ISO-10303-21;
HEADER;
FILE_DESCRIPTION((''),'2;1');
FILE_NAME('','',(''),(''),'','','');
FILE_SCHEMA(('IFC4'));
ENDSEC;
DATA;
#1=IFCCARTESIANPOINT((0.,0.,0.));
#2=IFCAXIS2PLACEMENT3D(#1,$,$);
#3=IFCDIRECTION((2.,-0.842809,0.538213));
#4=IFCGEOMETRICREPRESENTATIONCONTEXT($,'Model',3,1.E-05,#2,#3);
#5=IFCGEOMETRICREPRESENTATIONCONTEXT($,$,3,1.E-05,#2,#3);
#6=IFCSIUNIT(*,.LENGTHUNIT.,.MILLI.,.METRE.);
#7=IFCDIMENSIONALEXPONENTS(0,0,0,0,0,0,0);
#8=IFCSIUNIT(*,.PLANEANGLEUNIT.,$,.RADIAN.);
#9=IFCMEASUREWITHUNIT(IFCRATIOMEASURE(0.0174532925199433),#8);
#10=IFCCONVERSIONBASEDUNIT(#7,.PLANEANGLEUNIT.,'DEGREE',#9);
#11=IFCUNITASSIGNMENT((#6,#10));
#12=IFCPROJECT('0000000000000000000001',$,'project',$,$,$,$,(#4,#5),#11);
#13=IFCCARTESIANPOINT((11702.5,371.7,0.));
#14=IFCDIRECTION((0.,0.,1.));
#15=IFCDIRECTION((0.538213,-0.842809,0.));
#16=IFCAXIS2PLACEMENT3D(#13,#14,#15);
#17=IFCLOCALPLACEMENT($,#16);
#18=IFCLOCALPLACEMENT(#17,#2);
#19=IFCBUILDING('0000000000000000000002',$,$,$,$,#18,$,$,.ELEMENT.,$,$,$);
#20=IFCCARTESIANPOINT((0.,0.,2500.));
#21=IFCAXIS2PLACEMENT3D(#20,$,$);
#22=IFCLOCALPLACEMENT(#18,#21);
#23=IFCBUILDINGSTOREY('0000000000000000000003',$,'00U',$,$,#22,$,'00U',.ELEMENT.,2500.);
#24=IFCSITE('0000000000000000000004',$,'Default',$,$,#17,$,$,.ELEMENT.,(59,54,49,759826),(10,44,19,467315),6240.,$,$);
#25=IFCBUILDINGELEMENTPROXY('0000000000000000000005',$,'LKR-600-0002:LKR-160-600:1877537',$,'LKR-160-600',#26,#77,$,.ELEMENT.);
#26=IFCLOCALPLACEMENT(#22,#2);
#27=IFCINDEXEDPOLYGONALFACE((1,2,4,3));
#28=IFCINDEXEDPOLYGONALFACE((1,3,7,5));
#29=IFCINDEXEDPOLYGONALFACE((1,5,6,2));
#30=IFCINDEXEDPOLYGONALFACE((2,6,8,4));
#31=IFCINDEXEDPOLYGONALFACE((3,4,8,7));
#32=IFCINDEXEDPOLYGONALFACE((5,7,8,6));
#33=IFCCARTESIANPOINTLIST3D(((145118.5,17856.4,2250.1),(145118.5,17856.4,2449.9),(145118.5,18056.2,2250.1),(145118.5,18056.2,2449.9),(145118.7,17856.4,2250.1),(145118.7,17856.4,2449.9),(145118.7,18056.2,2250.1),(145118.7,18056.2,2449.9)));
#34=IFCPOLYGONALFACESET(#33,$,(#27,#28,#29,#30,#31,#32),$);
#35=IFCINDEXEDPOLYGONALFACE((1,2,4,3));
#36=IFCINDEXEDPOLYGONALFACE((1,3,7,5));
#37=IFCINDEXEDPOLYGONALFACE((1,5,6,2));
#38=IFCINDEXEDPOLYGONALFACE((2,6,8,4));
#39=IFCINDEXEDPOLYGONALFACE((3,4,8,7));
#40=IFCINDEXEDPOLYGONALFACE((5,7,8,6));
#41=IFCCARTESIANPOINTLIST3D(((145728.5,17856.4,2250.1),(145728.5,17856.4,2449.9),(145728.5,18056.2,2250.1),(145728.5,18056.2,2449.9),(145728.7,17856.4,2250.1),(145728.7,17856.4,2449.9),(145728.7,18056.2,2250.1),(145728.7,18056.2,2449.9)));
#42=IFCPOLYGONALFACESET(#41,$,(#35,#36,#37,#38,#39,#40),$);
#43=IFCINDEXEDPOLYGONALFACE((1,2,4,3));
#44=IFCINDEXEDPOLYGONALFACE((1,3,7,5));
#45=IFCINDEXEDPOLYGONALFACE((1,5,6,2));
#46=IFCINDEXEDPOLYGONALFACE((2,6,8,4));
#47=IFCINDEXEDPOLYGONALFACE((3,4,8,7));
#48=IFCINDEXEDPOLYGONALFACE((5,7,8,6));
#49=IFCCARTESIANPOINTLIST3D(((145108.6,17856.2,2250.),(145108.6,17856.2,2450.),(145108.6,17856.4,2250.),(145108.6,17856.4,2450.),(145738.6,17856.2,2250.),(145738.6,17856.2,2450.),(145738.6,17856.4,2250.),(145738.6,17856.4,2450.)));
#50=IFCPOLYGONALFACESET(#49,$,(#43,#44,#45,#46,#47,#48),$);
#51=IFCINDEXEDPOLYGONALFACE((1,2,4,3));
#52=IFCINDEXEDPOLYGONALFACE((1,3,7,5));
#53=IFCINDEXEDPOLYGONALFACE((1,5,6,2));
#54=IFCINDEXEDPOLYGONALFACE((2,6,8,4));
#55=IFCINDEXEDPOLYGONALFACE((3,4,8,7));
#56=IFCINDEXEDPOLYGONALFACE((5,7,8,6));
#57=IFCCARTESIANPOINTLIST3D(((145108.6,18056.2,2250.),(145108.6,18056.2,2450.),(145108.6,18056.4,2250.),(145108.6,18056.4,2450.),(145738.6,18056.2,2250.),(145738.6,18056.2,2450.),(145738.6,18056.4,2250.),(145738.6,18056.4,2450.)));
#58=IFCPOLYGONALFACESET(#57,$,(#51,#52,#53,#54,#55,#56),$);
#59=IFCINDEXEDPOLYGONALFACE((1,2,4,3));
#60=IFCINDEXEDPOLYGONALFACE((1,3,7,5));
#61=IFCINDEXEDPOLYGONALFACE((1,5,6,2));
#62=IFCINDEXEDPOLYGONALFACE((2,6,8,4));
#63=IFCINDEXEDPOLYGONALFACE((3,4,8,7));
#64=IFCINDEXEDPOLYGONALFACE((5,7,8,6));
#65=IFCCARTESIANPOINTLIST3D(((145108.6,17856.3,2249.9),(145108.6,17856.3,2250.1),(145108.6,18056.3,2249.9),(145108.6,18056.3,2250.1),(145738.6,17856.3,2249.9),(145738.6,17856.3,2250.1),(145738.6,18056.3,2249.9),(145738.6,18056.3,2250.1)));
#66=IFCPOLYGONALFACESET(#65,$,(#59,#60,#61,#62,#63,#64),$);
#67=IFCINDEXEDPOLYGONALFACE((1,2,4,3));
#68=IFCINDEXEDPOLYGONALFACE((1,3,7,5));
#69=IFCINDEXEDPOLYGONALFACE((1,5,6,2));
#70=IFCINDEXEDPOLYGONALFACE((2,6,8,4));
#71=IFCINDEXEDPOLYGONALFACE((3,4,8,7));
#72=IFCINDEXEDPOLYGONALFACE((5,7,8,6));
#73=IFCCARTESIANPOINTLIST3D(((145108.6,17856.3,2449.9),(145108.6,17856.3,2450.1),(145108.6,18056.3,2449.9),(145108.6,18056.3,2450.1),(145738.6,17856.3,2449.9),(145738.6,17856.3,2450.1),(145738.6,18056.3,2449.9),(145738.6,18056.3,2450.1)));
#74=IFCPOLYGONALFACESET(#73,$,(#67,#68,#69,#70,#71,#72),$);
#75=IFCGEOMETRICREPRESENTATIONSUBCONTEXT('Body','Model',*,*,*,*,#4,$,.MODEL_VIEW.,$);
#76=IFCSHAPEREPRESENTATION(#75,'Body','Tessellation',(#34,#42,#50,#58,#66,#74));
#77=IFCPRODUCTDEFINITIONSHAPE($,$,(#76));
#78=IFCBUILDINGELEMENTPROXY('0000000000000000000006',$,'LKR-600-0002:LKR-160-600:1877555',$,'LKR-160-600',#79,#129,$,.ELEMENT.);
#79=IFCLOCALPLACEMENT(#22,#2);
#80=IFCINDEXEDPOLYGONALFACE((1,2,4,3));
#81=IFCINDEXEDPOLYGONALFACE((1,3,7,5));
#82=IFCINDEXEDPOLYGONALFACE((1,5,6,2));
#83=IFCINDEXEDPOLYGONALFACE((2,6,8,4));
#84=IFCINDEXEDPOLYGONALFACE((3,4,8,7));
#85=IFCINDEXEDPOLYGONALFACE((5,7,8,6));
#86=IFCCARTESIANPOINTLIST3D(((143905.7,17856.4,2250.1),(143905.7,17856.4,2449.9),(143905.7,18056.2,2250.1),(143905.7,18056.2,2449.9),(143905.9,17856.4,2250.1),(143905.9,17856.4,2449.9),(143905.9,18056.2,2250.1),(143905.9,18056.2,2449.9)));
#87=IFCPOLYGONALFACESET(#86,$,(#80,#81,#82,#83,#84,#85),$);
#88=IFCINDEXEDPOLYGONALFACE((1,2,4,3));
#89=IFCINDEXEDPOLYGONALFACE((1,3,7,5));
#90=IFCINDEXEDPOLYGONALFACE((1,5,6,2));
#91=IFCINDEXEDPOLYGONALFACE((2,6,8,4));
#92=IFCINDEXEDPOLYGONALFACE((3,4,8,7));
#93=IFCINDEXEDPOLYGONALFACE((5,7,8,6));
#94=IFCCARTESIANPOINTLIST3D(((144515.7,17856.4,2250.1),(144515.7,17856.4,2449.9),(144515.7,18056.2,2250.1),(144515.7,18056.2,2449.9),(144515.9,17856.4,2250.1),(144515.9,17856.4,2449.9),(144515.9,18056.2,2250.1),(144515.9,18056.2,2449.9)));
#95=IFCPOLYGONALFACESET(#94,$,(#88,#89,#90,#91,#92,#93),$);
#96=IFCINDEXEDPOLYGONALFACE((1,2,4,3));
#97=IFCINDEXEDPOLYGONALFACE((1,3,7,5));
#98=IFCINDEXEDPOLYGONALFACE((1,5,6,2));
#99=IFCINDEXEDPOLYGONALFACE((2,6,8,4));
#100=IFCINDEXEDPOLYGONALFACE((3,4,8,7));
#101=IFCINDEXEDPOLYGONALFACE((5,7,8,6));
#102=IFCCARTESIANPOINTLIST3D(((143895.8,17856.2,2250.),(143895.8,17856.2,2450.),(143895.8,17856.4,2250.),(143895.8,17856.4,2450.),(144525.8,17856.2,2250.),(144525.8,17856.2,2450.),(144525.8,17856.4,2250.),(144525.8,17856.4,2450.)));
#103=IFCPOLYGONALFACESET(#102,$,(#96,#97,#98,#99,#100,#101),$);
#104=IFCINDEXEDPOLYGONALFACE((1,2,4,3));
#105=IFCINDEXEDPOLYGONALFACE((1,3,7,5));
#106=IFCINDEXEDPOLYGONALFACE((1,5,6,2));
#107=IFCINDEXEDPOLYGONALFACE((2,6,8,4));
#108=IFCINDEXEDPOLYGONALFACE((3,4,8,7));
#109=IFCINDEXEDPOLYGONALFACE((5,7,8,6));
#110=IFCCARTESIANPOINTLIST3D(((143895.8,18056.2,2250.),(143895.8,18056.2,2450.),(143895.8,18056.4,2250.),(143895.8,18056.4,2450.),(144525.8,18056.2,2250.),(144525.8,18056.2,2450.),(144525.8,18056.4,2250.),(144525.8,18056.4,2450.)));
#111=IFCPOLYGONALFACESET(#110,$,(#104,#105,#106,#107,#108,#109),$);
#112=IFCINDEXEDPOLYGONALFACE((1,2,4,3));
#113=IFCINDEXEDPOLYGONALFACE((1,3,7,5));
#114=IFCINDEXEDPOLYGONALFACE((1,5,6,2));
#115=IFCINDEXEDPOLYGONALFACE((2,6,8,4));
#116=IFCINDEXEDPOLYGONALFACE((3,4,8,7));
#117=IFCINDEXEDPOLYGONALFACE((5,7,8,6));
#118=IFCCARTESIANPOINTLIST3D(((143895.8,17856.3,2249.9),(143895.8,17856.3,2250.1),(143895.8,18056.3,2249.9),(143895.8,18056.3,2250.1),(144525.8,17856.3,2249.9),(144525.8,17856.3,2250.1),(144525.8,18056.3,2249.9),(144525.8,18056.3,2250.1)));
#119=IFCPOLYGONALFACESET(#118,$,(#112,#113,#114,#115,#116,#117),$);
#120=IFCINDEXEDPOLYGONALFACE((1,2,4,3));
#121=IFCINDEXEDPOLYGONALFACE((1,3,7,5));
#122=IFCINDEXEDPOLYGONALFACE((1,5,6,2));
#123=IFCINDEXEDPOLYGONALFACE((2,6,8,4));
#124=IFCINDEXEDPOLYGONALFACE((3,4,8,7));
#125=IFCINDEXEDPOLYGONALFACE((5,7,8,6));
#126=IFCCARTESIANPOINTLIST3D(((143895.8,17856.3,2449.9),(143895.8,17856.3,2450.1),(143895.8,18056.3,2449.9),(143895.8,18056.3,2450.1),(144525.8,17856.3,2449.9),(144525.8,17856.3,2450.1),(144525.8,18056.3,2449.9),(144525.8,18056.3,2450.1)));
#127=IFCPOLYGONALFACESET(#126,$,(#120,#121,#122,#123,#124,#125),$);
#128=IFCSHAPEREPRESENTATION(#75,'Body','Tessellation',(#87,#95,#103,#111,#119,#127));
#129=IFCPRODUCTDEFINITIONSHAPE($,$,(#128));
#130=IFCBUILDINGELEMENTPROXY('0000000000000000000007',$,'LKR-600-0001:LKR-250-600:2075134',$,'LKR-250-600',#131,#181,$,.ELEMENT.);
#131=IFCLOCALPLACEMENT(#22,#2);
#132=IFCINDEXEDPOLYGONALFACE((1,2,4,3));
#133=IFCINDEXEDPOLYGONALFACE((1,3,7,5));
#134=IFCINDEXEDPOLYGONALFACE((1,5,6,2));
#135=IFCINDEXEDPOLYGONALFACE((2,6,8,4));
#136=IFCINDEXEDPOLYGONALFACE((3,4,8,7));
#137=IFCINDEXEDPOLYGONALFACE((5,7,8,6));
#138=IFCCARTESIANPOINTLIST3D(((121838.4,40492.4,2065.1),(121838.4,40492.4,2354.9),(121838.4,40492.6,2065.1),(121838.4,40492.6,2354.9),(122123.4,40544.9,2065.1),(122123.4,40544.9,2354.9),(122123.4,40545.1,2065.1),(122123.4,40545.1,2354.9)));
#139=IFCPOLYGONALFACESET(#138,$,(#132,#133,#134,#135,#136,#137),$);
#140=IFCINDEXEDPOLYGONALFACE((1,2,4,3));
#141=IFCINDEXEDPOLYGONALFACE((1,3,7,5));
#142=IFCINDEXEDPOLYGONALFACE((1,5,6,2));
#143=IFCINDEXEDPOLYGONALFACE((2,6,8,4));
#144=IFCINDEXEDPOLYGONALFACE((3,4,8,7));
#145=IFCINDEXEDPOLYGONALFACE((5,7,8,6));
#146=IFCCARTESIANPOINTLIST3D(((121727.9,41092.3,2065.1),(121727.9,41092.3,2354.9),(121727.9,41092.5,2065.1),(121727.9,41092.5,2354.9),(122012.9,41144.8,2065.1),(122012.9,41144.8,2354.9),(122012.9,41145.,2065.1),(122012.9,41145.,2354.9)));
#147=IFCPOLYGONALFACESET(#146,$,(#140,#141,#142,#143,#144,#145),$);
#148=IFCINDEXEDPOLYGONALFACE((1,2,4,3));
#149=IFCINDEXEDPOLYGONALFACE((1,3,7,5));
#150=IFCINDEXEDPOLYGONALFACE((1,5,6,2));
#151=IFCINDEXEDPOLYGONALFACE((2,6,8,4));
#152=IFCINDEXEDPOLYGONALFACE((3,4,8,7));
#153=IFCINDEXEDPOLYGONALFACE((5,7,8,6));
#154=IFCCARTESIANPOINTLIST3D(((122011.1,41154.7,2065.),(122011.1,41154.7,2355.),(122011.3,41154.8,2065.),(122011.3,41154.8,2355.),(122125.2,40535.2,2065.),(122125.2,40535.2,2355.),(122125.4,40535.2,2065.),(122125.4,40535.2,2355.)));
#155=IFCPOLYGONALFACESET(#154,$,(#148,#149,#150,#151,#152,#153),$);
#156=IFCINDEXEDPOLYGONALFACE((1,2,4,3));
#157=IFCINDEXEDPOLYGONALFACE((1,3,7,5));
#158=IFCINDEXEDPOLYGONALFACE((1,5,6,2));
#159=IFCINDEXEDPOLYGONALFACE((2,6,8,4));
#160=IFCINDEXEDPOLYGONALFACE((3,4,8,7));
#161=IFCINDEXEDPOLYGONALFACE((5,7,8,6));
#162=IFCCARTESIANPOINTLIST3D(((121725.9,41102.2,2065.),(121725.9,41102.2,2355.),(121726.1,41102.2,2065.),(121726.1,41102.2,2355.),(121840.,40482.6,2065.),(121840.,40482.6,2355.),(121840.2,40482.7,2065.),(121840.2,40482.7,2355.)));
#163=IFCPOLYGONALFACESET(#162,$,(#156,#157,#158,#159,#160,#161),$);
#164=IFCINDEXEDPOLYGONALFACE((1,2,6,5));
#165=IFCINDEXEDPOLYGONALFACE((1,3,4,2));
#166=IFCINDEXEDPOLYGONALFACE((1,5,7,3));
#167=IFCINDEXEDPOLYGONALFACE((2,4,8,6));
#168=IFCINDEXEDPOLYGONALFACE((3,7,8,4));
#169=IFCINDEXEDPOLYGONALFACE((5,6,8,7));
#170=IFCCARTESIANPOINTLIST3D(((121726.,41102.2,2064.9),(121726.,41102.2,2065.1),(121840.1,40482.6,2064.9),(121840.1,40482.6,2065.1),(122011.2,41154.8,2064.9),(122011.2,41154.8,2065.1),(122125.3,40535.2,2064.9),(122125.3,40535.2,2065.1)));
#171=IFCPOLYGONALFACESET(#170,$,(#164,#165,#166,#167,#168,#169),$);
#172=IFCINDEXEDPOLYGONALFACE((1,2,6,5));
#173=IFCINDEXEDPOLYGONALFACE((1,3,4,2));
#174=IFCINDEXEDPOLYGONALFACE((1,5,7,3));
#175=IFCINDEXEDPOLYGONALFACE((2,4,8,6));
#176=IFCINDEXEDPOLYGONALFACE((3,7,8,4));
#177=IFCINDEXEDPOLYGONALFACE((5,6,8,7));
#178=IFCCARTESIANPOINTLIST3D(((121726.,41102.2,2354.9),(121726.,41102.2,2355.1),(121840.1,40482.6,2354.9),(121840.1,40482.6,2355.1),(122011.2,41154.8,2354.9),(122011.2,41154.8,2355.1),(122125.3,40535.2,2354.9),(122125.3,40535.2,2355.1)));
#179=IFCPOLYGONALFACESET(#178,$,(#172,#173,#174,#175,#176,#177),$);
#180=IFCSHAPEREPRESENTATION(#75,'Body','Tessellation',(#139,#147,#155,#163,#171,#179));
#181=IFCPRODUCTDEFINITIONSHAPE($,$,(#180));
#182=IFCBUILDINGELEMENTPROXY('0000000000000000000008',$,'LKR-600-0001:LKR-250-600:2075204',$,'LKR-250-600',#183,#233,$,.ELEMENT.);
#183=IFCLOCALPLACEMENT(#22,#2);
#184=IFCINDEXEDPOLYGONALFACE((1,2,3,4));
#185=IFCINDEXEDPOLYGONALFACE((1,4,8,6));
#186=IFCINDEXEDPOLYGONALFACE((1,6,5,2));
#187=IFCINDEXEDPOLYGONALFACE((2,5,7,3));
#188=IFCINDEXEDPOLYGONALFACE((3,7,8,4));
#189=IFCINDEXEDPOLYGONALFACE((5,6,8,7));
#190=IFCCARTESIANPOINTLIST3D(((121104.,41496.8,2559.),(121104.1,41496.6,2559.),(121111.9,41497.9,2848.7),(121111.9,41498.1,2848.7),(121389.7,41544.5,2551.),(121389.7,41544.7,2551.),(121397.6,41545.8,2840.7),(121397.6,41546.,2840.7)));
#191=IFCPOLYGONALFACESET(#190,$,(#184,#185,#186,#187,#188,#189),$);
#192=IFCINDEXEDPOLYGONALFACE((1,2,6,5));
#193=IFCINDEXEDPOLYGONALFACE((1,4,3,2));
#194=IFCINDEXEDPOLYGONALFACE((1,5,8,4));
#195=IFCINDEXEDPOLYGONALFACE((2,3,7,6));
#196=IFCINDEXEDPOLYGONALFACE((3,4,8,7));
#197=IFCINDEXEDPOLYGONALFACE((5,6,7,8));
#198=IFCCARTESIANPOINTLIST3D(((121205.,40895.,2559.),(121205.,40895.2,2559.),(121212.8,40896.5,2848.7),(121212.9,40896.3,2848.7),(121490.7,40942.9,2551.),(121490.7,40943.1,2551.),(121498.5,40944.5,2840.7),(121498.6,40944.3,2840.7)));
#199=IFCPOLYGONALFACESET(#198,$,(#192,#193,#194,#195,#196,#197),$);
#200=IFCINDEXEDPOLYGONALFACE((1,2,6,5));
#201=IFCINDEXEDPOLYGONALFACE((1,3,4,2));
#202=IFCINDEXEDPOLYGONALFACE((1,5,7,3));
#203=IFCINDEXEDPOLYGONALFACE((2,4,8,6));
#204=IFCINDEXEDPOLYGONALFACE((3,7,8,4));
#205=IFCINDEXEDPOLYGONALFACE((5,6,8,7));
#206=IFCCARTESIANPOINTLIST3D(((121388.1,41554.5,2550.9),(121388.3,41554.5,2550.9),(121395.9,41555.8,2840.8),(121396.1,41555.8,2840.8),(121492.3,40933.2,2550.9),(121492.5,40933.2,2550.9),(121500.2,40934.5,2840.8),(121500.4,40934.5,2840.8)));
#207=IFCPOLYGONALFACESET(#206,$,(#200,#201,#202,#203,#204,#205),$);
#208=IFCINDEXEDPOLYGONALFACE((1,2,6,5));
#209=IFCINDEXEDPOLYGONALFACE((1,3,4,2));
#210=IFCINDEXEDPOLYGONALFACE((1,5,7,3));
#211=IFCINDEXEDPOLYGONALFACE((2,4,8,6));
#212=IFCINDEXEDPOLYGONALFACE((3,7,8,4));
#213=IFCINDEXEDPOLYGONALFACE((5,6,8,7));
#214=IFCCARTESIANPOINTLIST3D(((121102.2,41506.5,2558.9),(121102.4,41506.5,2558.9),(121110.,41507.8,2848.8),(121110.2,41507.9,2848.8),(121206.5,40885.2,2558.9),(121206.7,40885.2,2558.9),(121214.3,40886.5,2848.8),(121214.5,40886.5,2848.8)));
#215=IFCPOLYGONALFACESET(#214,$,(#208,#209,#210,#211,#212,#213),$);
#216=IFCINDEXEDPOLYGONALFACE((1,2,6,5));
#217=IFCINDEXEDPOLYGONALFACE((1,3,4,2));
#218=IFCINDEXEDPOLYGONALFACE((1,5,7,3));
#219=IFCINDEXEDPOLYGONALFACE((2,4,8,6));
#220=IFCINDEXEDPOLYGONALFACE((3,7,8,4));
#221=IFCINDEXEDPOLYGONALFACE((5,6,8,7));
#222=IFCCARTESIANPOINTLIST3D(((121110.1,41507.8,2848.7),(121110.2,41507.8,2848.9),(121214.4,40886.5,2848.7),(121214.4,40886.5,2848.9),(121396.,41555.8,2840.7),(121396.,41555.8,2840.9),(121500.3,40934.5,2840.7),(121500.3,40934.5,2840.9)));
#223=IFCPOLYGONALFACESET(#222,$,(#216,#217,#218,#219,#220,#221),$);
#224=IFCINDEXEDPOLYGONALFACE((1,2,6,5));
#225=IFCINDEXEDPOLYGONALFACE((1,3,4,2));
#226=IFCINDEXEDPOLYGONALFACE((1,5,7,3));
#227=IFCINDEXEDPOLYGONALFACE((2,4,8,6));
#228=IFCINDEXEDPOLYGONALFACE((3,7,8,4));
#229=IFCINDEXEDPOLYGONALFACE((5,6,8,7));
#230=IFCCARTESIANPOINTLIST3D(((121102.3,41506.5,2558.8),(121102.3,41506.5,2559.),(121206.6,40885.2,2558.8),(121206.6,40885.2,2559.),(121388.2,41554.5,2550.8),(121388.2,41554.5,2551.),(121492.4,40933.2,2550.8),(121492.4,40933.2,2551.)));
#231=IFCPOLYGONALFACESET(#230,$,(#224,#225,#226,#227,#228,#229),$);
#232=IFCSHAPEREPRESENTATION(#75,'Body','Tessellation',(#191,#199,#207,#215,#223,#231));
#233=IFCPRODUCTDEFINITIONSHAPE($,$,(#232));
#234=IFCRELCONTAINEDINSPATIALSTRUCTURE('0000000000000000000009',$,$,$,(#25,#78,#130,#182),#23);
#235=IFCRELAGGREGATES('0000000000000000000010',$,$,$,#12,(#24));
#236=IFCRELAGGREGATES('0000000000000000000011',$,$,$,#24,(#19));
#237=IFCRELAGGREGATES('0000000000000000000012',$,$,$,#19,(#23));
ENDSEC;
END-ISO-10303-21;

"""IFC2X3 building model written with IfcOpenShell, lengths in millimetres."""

from ifc_helpers import new_model, entity, si_unit, converted_unit, direction, frame, frame_2d, origin, origin_2d_with_axis, place, context, subcontext, project, spatial, rectangle, extrude, source, transform, mapped, element, save


model = new_model("IFC2X3")

# Units and contexts
model_context = context("Model", 3, precision=1e-05, world=origin(), true_north=direction((2.0, -0.842809, 0.538213)))
context_of_model = context(None, 3, precision=1e-05, world=origin(), true_north=direction((2.0, -0.842809, 0.538213)))
body_context = subcontext(model_context, "Body", "Model", "MODEL_VIEW")
ifc_project = project(units=[si_unit("LENGTHUNIT", "METRE", prefix="MILLI"), converted_unit("PLANEANGLEUNIT", "DEGREE", entity("IfcRatioMeasure", 0.0174532925199433), si_unit("PLANEANGLEUNIT", "RADIAN"), dimensions=[0, 0, 0, 0, 0, 0, 0])], contexts=[model_context, context_of_model])

# Site, building, storey
site_placement = place(None, frame((11702.5, 371.7, 0.0), z_axis=(0.0, 0.0, 1.0), x_axis=(0.538213, -0.842809, 0.0)))
site = spatial("IfcSite", under=ifc_project, at=site_placement, Name="Default", CompositionType="ELEMENT", RefLatitude=(59, 54, 49, 759826), RefLongitude=(10, 44, 19, 467315), RefElevation=6240.0)
building_placement = place(site_placement, origin())
building = spatial("IfcBuilding", under=site, at=building_placement, CompositionType="ELEMENT")
storey_placement = place(building_placement, frame((0.0, 0.0, 2500.0)))
storey = spatial("IfcBuildingStorey", under=building, at=storey_placement, Name="00U", LongName="00U", CompositionType="ELEMENT", Elevation=2500.0)

# Building element proxies
shared_shape_1 = source(origin(), body_context, "Body", "SweptSolid", [
    extrude(rectangle(XDim=0.2, YDim=199.8, at=frame_2d((0.0, 0.0), x_axis=(1.0, 0.0))), frame((305.0, 0.0, -99.9)), (0.0, 0.0, 1.0), 199.8),
    extrude(rectangle(XDim=0.2, YDim=199.8, at=frame_2d((0.0, 0.0), x_axis=(1.0, 0.0))), frame((-305.0, 0.0, -99.9)), (0.0, 0.0, 1.0), 199.8),
    extrude(rectangle(XDim=0.2, YDim=630.0, at=frame_2d((0.0, 0.0), x_axis=(1.0, 0.0))), frame((0.0, 100.0, -100.0), z_axis=(0.0, 0.0, 1.0), x_axis=(0.0, 1.0, 0.0)), (0.0, 0.0, 1.0), 200.0),
    extrude(rectangle(XDim=0.2, YDim=630.0, at=frame_2d((0.0, 0.0), x_axis=(1.0, 0.0))), frame((0.0, -100.0, -100.0), z_axis=(0.0, 0.0, 1.0), x_axis=(0.0, 1.0, 0.0)), (0.0, 0.0, 1.0), 200.0),
    extrude(rectangle(XDim=200.0, YDim=630.0, at=origin_2d_with_axis()), frame((0.0, 0.0, -100.1), z_axis=(0.0, 0.0, 1.0), x_axis=(0.0, -1.0, 0.0)), (0.0, 0.0, 1.0), 0.2),
    extrude(rectangle(XDim=200.0, YDim=630.0, at=origin_2d_with_axis()), frame((0.0, 0.0, 99.9), z_axis=(0.0, 0.0, 1.0), x_axis=(0.0, -1.0, 0.0)), (0.0, 0.0, 1.0), 0.2),
])
for number, where, z_axis, x_axis, name in (
    (1, (145423.6, 17956.3, 2350.0), (0.0, 0.0, 1.0), (-1.0, 0.0, 0.0), "LKR-600-0002:LKR-160-600:1877537"),
    (2, (144210.8, 17956.3, 2350.0), (0.0, 0.0, 1.0), (-1.0, 0.0, 0.0), "LKR-600-0002:LKR-160-600:1877555"),
):
    element("IfcBuildingElementProxy", number, at=place(storey_placement, frame(where, z_axis=z_axis, x_axis=x_axis)), inside=storey, Name=name, ObjectType="LKR-160-600", CompositionType="ELEMENT", context=body_context, shape_type="MappedRepresentation", body=[
        mapped(shared_shape_1, transform((0.0, 0.0, 0.0), scale=1.0)),
    ])
shared_shape_2 = source(origin(), body_context, "Body", "SweptSolid", [
    extrude(rectangle(XDim=0.2, YDim=289.8, at=frame_2d((0.0, 0.0), x_axis=(1.0, 0.0))), frame((305.0, 0.0, -144.9)), (0.0, 0.0, 1.0), 289.8),
    extrude(rectangle(XDim=0.2, YDim=289.8, at=frame_2d((0.0, 0.0), x_axis=(1.0, 0.0))), frame((-305.0, 0.0, -144.9)), (0.0, 0.0, 1.0), 289.8),
    extrude(rectangle(XDim=0.2, YDim=630.0, at=frame_2d((0.0, 0.0), x_axis=(1.0, 0.0))), frame((0.0, 145.0, -145.0), z_axis=(0.0, 0.0, 1.0), x_axis=(0.0, 1.0, 0.0)), (0.0, 0.0, 1.0), 290.0),
    extrude(rectangle(XDim=0.2, YDim=630.0, at=frame_2d((0.0, 0.0), x_axis=(1.0, 0.0))), frame((0.0, -145.0, -145.0), z_axis=(0.0, 0.0, 1.0), x_axis=(0.0, 1.0, 0.0)), (0.0, 0.0, 1.0), 290.0),
    extrude(rectangle(XDim=290.0, YDim=630.0, at=origin_2d_with_axis()), frame((0.0, 0.0, -145.1), z_axis=(0.0, 0.0, 1.0), x_axis=(0.0, -1.0, 0.0)), (0.0, 0.0, 1.0), 0.2),
    extrude(rectangle(XDim=290.0, YDim=630.0, at=origin_2d_with_axis()), frame((0.0, 0.0, 144.9), z_axis=(0.0, 0.0, 1.0), x_axis=(0.0, -1.0, 0.0)), (0.0, 0.0, 1.0), 0.2),
])
for number, where, z_axis, x_axis, name in (
    (3, (121925.6, 40818.7, 2210.0), (0.0, 0.0, 1.0), (0.18117, -0.983452, 0.0), "LKR-600-0001:LKR-250-600:2075134"),
    (4, (121301.3, 41220.5, 2699.9), (-0.027138, -0.004555, -0.999621), (-0.165517, 0.986207, 0.0), "LKR-600-0001:LKR-250-600:2075204"),
):
    element("IfcBuildingElementProxy", number, at=place(storey_placement, frame(where, z_axis=z_axis, x_axis=x_axis)), inside=storey, Name=name, ObjectType="LKR-250-600", CompositionType="ELEMENT", context=body_context, shape_type="MappedRepresentation", body=[
        mapped(shared_shape_2, transform((0.0, 0.0, 0.0), scale=1.0)),
    ])

save(model, "model.ifc")
